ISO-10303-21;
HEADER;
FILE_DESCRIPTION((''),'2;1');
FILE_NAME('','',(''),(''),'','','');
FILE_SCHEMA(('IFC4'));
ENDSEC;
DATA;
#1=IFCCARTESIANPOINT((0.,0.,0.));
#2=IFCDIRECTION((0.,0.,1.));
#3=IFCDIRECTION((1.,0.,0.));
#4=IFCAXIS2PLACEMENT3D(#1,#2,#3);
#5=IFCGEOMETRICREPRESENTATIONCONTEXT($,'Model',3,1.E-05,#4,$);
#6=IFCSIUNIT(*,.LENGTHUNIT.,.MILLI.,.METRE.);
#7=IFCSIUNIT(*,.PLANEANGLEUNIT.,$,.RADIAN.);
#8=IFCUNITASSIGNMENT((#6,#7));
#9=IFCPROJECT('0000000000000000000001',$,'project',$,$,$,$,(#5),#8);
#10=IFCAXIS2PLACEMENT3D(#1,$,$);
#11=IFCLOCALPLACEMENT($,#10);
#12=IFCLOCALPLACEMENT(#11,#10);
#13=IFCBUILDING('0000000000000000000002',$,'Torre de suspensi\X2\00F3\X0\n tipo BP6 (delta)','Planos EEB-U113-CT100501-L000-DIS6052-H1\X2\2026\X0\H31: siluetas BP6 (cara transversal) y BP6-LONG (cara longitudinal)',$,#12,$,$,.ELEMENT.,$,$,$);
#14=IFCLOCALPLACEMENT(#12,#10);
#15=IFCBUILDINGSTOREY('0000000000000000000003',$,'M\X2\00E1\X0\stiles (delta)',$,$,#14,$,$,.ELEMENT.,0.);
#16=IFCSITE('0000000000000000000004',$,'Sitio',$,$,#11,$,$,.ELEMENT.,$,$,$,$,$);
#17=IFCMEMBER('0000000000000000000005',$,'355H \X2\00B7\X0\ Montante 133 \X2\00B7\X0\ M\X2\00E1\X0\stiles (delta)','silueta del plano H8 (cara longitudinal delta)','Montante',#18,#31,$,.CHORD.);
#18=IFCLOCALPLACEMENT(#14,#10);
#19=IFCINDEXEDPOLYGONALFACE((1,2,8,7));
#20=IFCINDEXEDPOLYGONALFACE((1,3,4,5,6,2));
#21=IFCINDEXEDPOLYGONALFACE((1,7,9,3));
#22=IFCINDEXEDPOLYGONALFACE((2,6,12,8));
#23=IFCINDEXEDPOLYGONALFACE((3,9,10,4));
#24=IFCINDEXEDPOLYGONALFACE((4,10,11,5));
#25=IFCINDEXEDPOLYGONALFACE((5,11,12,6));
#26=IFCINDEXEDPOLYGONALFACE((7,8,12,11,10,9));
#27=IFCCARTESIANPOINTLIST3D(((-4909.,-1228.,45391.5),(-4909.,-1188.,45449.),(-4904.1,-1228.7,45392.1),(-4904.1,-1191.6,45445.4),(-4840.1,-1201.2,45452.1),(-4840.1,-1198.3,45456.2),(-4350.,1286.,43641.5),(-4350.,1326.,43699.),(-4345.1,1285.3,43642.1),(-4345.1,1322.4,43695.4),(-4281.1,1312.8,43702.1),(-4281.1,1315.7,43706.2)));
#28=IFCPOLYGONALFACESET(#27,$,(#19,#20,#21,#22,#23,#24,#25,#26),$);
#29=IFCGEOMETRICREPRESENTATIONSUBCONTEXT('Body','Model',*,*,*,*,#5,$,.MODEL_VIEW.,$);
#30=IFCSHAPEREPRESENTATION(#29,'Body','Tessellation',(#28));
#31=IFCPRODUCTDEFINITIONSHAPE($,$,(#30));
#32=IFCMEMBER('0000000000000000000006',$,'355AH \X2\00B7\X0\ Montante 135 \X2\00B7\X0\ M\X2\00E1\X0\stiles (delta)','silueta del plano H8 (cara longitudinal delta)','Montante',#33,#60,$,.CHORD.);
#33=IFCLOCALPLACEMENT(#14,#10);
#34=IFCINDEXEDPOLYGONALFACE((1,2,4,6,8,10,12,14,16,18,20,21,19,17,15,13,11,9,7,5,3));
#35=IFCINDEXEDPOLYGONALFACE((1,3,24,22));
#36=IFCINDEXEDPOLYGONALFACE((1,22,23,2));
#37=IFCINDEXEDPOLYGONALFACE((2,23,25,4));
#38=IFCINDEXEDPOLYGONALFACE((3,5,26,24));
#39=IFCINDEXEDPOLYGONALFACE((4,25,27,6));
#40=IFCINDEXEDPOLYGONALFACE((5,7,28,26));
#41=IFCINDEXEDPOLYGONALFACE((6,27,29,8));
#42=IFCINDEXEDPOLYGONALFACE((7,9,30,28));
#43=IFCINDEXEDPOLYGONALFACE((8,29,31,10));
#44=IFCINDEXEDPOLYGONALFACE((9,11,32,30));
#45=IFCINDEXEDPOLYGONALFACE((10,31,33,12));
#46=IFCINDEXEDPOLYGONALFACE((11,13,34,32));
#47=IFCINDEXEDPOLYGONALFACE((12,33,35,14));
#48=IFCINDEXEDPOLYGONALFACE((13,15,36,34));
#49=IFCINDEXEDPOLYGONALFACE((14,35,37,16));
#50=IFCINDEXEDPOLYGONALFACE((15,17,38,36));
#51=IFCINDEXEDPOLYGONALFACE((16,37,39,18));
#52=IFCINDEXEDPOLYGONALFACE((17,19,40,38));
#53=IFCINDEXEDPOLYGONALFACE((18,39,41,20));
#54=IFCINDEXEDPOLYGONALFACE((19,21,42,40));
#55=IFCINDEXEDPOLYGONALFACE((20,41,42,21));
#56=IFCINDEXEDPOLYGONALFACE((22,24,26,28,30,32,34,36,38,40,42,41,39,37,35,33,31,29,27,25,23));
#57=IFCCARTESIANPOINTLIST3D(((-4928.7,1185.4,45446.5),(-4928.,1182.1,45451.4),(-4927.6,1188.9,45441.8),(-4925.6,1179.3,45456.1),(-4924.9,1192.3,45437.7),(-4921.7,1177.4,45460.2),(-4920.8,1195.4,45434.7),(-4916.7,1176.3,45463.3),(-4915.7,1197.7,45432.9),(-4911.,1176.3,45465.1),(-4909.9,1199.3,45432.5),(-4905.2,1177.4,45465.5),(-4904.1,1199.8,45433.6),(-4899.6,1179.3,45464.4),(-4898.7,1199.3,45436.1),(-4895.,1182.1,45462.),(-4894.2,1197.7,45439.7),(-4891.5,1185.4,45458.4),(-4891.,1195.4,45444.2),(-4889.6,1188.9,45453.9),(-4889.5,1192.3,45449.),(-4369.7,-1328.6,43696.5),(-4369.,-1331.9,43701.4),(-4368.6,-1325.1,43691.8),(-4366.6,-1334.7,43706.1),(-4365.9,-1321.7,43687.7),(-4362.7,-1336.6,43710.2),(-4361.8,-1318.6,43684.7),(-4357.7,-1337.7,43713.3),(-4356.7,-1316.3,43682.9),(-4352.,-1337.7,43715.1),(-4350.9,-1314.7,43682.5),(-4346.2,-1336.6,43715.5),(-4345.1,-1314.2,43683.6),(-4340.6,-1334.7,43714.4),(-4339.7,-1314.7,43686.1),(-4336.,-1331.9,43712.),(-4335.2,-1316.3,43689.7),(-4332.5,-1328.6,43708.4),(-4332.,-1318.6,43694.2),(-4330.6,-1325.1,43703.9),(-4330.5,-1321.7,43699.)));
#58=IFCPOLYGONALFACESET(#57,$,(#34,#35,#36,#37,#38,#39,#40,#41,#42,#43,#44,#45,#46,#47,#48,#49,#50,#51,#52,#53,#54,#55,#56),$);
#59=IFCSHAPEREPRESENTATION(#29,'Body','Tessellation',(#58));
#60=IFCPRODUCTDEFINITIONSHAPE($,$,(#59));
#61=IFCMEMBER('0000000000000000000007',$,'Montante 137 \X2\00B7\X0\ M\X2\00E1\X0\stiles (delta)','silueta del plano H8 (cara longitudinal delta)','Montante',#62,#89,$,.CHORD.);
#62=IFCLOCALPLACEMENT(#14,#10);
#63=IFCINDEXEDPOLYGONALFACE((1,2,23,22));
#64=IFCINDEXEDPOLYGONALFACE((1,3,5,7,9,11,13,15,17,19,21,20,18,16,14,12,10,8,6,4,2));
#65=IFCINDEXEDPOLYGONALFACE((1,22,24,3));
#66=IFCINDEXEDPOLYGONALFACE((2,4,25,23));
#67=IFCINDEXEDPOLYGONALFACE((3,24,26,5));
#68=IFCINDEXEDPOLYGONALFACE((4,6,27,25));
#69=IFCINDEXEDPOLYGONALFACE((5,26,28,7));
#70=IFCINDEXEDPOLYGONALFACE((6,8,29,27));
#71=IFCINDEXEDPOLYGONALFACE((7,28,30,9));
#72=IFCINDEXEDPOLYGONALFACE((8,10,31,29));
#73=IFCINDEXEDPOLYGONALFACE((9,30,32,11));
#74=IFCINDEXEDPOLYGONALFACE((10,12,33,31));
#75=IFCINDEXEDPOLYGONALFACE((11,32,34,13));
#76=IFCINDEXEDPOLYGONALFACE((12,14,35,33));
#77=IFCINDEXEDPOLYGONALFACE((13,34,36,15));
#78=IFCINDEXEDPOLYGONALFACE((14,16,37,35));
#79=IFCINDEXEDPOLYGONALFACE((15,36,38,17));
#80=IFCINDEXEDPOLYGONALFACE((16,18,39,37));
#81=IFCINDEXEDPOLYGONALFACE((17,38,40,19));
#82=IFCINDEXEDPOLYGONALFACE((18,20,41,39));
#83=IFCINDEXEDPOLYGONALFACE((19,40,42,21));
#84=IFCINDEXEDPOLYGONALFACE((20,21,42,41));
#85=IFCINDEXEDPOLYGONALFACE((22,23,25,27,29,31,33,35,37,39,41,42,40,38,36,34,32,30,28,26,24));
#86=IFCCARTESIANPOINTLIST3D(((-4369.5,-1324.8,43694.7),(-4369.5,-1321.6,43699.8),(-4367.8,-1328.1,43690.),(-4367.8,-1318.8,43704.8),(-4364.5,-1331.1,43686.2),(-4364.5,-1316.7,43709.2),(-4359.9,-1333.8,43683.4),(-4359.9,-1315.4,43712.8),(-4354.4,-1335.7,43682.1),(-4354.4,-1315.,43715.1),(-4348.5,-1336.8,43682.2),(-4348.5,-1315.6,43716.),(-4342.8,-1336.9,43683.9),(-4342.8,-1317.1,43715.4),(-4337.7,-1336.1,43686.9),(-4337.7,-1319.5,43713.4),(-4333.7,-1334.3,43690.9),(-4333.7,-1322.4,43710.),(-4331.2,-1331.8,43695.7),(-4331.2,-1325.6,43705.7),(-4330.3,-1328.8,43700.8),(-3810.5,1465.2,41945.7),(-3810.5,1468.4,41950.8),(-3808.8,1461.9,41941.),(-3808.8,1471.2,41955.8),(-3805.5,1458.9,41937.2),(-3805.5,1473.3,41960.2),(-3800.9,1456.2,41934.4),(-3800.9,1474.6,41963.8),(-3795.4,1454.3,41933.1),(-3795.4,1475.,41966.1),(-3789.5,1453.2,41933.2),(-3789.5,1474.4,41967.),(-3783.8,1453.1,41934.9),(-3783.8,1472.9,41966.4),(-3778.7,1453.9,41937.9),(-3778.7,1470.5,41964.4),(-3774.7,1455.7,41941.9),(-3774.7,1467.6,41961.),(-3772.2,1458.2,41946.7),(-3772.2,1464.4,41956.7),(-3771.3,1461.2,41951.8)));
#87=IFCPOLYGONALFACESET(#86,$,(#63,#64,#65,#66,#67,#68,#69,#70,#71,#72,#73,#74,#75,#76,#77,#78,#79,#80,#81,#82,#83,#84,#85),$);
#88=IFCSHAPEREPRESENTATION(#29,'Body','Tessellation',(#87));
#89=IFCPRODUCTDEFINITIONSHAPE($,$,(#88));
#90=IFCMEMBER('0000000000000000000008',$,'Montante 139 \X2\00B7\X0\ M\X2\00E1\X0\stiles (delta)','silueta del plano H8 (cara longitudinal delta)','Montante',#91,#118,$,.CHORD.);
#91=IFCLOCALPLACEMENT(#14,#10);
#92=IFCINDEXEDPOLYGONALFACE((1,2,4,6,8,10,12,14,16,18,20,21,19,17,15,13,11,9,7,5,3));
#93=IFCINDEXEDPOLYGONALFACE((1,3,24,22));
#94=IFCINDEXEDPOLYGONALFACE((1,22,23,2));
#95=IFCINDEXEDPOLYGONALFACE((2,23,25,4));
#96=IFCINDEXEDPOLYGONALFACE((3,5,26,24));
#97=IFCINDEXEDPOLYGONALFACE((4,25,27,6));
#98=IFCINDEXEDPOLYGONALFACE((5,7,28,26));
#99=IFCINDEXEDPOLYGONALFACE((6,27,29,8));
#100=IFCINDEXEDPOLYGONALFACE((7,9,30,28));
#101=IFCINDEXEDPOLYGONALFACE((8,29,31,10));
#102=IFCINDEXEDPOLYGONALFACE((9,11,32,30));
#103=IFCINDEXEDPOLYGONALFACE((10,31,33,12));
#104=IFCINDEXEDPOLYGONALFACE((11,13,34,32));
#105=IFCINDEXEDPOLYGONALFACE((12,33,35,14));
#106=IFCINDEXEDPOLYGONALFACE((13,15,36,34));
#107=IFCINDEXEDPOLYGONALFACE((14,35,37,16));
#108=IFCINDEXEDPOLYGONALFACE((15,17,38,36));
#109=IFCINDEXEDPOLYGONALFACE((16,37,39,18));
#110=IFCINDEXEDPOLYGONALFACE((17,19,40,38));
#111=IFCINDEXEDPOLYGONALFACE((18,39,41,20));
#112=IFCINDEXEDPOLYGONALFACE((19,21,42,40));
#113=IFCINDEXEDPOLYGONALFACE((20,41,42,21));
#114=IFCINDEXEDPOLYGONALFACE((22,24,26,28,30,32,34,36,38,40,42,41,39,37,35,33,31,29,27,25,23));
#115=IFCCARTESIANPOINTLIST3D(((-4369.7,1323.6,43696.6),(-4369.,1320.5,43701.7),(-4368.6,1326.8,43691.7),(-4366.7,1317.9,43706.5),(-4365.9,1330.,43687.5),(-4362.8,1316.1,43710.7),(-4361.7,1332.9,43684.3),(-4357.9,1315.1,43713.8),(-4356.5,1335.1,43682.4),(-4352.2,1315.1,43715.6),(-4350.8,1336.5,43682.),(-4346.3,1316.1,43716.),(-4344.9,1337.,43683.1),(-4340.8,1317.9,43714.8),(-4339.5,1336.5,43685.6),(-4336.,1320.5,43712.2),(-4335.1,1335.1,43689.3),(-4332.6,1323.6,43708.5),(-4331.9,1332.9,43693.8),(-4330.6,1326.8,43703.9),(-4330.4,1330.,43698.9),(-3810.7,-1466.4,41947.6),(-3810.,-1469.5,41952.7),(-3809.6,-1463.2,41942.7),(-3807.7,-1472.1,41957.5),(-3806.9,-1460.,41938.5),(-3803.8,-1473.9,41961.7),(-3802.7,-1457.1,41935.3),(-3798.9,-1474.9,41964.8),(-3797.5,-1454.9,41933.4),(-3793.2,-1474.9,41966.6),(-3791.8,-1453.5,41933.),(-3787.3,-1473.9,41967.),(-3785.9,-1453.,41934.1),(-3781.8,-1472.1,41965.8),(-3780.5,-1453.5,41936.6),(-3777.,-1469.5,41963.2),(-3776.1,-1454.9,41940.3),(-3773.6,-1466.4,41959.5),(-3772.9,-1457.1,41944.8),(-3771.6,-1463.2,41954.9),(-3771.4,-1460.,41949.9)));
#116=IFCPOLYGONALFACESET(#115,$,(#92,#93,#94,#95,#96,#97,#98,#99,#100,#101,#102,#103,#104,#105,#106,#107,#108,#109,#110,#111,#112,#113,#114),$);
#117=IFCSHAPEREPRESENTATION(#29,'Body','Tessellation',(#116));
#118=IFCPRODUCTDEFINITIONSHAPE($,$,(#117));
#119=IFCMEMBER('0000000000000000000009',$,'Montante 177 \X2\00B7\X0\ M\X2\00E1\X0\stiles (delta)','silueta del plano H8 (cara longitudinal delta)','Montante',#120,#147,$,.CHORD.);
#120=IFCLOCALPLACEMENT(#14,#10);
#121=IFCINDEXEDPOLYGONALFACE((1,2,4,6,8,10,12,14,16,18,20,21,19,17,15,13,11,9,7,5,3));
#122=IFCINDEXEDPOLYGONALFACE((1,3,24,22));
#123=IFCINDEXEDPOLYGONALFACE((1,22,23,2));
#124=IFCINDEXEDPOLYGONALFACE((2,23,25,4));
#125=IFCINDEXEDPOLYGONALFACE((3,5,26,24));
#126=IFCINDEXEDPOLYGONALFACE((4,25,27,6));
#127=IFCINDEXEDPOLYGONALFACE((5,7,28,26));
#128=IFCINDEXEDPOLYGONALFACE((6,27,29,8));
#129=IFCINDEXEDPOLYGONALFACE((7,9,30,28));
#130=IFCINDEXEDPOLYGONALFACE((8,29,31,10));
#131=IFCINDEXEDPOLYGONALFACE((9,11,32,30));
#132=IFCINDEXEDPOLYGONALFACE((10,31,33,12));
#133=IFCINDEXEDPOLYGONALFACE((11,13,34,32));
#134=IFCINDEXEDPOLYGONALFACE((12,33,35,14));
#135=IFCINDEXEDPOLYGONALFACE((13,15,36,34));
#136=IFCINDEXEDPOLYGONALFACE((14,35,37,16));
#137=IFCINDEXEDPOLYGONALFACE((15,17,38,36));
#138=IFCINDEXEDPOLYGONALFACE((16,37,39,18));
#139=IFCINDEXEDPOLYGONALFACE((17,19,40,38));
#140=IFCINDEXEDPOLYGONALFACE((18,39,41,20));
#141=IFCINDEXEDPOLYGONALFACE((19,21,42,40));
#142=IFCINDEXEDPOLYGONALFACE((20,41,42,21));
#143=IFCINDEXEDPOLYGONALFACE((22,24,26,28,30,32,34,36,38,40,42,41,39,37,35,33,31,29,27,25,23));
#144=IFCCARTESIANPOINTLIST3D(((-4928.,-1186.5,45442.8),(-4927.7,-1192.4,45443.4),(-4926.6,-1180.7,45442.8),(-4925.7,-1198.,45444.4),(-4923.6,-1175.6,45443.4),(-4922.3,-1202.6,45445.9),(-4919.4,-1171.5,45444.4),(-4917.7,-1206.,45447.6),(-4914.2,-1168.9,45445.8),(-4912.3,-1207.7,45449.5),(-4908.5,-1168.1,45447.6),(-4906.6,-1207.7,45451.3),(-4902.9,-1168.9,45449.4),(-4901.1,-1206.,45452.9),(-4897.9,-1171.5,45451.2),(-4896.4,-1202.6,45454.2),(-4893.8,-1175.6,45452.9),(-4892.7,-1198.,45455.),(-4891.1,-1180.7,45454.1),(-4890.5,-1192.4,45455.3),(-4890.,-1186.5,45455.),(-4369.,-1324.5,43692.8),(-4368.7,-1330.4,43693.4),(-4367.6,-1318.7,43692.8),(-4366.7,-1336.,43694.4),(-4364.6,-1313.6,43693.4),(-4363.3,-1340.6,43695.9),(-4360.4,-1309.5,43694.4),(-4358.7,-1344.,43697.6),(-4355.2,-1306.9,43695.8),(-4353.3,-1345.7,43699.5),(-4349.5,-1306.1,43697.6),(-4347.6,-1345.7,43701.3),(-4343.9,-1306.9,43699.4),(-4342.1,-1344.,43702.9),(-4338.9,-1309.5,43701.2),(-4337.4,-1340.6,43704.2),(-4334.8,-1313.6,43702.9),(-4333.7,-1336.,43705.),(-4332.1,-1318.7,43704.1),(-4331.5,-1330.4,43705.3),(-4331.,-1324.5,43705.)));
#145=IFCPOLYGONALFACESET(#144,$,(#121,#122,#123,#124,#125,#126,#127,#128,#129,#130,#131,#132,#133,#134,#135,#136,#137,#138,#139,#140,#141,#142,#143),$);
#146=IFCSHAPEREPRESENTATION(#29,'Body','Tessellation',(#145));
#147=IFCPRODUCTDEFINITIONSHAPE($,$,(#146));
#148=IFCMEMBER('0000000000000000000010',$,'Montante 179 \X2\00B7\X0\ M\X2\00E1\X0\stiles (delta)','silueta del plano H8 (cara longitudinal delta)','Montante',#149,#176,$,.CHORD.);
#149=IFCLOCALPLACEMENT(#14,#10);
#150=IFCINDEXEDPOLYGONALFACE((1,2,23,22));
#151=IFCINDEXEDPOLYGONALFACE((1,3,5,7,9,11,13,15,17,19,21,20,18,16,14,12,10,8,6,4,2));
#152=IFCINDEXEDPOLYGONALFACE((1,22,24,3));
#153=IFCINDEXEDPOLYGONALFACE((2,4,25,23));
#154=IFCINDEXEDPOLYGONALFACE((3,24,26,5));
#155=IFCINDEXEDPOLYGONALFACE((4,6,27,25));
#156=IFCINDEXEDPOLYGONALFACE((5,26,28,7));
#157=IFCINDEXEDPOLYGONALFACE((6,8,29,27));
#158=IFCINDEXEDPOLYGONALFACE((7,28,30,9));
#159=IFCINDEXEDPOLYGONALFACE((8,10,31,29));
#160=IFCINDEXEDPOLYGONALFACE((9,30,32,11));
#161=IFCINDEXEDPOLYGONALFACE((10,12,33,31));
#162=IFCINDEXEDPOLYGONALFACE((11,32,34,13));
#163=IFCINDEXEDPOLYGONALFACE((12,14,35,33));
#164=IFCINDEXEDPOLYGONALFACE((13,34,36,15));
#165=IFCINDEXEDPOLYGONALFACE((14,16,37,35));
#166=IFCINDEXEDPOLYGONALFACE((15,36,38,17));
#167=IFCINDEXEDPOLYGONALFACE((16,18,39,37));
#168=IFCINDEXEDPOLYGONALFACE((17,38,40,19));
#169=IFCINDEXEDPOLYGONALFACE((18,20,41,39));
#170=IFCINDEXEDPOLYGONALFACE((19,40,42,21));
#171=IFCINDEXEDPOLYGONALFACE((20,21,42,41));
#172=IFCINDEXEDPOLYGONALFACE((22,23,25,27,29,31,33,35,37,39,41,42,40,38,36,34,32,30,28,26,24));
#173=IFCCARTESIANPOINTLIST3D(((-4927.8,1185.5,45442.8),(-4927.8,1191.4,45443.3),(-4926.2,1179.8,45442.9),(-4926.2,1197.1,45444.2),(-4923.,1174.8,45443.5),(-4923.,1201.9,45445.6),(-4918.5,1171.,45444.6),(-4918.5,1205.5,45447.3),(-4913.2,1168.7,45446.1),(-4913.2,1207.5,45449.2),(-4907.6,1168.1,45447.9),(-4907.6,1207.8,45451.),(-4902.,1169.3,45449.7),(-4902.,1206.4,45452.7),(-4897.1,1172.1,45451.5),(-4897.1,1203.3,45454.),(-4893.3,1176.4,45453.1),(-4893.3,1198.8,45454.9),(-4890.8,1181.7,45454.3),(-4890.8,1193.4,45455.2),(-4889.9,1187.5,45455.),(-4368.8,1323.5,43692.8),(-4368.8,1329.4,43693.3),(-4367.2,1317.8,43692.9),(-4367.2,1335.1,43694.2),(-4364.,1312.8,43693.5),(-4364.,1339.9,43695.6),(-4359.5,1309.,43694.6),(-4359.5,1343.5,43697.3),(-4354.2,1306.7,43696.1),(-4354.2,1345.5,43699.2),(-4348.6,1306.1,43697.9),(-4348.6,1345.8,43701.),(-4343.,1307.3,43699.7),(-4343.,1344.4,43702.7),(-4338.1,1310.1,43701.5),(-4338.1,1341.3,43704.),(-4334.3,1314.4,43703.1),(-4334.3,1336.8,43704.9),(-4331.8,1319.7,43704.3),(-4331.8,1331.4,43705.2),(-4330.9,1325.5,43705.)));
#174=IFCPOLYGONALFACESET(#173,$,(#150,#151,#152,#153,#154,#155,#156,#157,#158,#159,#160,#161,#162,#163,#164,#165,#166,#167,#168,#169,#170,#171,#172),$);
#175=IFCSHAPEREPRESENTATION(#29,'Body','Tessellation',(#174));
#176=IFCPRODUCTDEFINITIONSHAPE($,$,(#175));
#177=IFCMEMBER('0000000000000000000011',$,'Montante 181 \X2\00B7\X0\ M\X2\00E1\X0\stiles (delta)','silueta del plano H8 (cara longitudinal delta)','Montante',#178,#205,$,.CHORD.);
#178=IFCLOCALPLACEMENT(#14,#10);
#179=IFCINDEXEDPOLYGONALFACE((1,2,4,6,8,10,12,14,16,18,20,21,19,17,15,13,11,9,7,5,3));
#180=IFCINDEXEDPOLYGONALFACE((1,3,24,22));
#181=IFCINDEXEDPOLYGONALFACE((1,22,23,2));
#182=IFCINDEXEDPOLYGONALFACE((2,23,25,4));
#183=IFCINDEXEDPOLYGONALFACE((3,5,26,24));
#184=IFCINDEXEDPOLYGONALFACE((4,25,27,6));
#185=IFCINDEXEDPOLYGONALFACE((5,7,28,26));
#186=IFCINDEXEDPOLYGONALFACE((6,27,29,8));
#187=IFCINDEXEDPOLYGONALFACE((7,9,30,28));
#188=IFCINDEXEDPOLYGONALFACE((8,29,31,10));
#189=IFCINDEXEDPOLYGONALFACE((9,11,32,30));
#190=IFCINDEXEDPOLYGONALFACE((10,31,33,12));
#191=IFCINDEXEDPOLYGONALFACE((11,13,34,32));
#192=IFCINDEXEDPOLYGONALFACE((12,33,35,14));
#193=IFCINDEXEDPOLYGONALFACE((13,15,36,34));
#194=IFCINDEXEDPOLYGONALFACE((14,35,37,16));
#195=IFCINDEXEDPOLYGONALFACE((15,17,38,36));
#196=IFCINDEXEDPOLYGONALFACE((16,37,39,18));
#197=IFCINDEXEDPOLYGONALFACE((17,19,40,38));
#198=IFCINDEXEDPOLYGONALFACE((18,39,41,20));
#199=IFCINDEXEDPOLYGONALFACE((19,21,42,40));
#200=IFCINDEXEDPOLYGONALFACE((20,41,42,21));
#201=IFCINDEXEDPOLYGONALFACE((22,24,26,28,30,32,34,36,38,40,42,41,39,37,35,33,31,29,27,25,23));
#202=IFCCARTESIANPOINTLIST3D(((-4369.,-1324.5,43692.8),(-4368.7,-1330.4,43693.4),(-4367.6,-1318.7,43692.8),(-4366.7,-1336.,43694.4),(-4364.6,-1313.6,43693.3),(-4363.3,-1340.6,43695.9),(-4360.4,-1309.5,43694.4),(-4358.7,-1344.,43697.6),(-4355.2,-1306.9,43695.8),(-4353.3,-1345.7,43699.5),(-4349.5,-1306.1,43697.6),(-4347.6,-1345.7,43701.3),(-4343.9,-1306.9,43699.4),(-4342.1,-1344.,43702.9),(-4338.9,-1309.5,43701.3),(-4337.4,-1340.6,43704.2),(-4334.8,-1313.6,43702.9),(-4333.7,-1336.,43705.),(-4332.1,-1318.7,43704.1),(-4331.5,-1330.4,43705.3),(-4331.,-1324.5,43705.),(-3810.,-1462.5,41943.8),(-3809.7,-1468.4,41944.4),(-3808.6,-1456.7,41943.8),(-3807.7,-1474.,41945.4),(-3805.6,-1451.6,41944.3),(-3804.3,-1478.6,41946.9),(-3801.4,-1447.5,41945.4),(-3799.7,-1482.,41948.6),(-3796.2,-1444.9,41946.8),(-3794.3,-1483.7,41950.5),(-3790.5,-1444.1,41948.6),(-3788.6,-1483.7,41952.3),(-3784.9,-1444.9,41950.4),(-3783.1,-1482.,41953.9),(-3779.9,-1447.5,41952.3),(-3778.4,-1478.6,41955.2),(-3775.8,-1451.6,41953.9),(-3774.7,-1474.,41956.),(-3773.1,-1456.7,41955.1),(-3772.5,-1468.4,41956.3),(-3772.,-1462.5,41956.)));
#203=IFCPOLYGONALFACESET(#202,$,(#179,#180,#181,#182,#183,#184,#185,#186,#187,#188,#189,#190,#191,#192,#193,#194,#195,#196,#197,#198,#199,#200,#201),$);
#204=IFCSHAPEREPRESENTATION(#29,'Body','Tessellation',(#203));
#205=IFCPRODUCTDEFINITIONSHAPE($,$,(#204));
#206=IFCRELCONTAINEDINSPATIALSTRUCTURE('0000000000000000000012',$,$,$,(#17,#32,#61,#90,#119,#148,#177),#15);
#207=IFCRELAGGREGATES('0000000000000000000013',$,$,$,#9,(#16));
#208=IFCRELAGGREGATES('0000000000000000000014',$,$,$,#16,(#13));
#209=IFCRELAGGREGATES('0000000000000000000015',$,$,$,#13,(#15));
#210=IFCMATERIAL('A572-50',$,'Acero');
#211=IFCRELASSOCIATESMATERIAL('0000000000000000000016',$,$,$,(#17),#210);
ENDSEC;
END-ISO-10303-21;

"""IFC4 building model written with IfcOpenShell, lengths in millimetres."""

from ifc_helpers import new_model, si_unit, frame, frame_2d, origin, origin_with_axes, place, context, subcontext, project, spatial, circle, l_section, extrude, material, element, save


model = new_model("IFC4")

# Units and contexts
model_context = context("Model", 3, precision=1e-05, world=origin_with_axes())
body_context = subcontext(model_context, "Body", "Model", "MODEL_VIEW")
ifc_project = project(units=[si_unit("LENGTHUNIT", "METRE", prefix="MILLI"), si_unit("PLANEANGLEUNIT", "RADIAN")], contexts=[model_context])

# Site, building, storey
site_placement = place(None, origin())
site = spatial("IfcSite", under=ifc_project, at=site_placement, Name="Sitio", CompositionType="ELEMENT")
building_placement = place(site_placement, origin())
building = spatial("IfcBuilding", under=site, at=building_placement, Name="Torre de suspensión tipo BP6 (delta)", Description="Planos EEB-U113-CT100501-L000-DIS6052-H1…H31: siluetas BP6 (cara transversal) y BP6-LONG (cara longitudinal)", CompositionType="ELEMENT")
storey_placement = place(building_placement, origin())
storey = spatial("IfcBuildingStorey", under=building, at=storey_placement, Name="Mástiles (delta)", CompositionType="ELEMENT", Elevation=0.0)

# Members
ifc_material = material(Name="A572-50", Category="Acero")
member_1_placement = place(storey_placement, frame((-4909.0, -1188.0, 45449.0), z_axis=(0.179529, 0.807398, -0.562031), x_axis=(0.983753, -0.147345, 0.102567)))
element("IfcMember", 1, at=member_1_placement, inside=storey, material=ifc_material, Name="355H · Montante 133 · Mástiles (delta)", Description="silueta del plano H8 (cara longitudinal delta)", ObjectType="Montante", PredefinedType="CHORD", context=body_context, shape_type="SweptSolid", body=[
    extrude(l_section(Depth=70.0, Width=70.0, Thickness=5.0, at=frame_2d((35.0, 35.0))), None, (0.0, 0.0, 1.0), 3113.7),
])
member_2_placement = place(storey_placement, frame((-4909.0, 1188.0, 45449.0), z_axis=(0.179529, -0.807398, -0.562031), x_axis=(0.245676, 0.590008, -0.769112)))
element("IfcMember", 2, at=member_2_placement, inside=storey, Name="355AH · Montante 135 · Mástiles (delta)", Description="silueta del plano H8 (cara longitudinal delta)", ObjectType="Montante", PredefinedType="CHORD", context=body_context, shape_type="SweptSolid", body=[
    extrude(circle(Radius=20.0), None, (0.0, 0.0, 1.0), 3113.7),
])
for number, where, z_axis, x_axis, name in (
    (3, (-4350.0, -1326.0, 43699.0), (0.167365, 0.83533, -0.523653), (0.985895, -0.141806, 0.088895), "Montante 137 · Mástiles (delta)"),
    (4, (-4350.0, 1326.0, 43699.0), (0.167365, -0.83533, -0.523653), (0.254308, 0.549749, -0.795678), "Montante 139 · Mástiles (delta)"),
):
    element("IfcMember", number, at=place(storey_placement, frame(where, z_axis=z_axis, x_axis=x_axis)), inside=storey, Name=name, Description="silueta del plano H8 (cara longitudinal delta)", ObjectType="Montante", PredefinedType="CHORD", context=body_context, shape_type="SweptSolid", body=[
        extrude(circle(Radius=20.0), None, (0.0, 0.0, 1.0), 3340.0),
    ])
for number, where, z_axis, x_axis, name in (
    (5, (-4909.0, -1188.0, 45449.0), (0.303427, -0.074907, -0.949906), (0.022793, 0.997191, -0.071355), "Montante 177 · Mástiles (delta)"),
    (6, (-4909.0, 1188.0, 45449.0), (0.303427, 0.074907, -0.949906), (0.952855, -0.023853, 0.302488), "Montante 179 · Mástiles (delta)"),
):
    element("IfcMember", number, at=place(storey_placement, frame(where, z_axis=z_axis, x_axis=x_axis)), inside=storey, Name=name, Description="silueta del plano H8 (cara longitudinal delta)", ObjectType="Montante", PredefinedType="CHORD", context=body_context, shape_type="SweptSolid", body=[
        extrude(circle(Radius=20.0), None, (0.0, 0.0, 1.0), 1842.3),
    ])
for number, where, z_axis, x_axis, name in (
    (7, (-4350.0, -1326.0, 43699.0), (0.303584, -0.074945, -0.949853), (0.022816, 0.997188, -0.071388), "Montante 181 · Mástiles (delta)"),
):
    element("IfcMember", number, at=place(storey_placement, frame(where, z_axis=z_axis, x_axis=x_axis)), inside=storey, Name=name, Description="silueta del plano H8 (cara longitudinal delta)", ObjectType="Montante", PredefinedType="CHORD", context=body_context, shape_type="SweptSolid", body=[
        extrude(circle(Radius=20.0), None, (0.0, 0.0, 1.0), 1841.3),
    ])

save(model, "model.ifc")
